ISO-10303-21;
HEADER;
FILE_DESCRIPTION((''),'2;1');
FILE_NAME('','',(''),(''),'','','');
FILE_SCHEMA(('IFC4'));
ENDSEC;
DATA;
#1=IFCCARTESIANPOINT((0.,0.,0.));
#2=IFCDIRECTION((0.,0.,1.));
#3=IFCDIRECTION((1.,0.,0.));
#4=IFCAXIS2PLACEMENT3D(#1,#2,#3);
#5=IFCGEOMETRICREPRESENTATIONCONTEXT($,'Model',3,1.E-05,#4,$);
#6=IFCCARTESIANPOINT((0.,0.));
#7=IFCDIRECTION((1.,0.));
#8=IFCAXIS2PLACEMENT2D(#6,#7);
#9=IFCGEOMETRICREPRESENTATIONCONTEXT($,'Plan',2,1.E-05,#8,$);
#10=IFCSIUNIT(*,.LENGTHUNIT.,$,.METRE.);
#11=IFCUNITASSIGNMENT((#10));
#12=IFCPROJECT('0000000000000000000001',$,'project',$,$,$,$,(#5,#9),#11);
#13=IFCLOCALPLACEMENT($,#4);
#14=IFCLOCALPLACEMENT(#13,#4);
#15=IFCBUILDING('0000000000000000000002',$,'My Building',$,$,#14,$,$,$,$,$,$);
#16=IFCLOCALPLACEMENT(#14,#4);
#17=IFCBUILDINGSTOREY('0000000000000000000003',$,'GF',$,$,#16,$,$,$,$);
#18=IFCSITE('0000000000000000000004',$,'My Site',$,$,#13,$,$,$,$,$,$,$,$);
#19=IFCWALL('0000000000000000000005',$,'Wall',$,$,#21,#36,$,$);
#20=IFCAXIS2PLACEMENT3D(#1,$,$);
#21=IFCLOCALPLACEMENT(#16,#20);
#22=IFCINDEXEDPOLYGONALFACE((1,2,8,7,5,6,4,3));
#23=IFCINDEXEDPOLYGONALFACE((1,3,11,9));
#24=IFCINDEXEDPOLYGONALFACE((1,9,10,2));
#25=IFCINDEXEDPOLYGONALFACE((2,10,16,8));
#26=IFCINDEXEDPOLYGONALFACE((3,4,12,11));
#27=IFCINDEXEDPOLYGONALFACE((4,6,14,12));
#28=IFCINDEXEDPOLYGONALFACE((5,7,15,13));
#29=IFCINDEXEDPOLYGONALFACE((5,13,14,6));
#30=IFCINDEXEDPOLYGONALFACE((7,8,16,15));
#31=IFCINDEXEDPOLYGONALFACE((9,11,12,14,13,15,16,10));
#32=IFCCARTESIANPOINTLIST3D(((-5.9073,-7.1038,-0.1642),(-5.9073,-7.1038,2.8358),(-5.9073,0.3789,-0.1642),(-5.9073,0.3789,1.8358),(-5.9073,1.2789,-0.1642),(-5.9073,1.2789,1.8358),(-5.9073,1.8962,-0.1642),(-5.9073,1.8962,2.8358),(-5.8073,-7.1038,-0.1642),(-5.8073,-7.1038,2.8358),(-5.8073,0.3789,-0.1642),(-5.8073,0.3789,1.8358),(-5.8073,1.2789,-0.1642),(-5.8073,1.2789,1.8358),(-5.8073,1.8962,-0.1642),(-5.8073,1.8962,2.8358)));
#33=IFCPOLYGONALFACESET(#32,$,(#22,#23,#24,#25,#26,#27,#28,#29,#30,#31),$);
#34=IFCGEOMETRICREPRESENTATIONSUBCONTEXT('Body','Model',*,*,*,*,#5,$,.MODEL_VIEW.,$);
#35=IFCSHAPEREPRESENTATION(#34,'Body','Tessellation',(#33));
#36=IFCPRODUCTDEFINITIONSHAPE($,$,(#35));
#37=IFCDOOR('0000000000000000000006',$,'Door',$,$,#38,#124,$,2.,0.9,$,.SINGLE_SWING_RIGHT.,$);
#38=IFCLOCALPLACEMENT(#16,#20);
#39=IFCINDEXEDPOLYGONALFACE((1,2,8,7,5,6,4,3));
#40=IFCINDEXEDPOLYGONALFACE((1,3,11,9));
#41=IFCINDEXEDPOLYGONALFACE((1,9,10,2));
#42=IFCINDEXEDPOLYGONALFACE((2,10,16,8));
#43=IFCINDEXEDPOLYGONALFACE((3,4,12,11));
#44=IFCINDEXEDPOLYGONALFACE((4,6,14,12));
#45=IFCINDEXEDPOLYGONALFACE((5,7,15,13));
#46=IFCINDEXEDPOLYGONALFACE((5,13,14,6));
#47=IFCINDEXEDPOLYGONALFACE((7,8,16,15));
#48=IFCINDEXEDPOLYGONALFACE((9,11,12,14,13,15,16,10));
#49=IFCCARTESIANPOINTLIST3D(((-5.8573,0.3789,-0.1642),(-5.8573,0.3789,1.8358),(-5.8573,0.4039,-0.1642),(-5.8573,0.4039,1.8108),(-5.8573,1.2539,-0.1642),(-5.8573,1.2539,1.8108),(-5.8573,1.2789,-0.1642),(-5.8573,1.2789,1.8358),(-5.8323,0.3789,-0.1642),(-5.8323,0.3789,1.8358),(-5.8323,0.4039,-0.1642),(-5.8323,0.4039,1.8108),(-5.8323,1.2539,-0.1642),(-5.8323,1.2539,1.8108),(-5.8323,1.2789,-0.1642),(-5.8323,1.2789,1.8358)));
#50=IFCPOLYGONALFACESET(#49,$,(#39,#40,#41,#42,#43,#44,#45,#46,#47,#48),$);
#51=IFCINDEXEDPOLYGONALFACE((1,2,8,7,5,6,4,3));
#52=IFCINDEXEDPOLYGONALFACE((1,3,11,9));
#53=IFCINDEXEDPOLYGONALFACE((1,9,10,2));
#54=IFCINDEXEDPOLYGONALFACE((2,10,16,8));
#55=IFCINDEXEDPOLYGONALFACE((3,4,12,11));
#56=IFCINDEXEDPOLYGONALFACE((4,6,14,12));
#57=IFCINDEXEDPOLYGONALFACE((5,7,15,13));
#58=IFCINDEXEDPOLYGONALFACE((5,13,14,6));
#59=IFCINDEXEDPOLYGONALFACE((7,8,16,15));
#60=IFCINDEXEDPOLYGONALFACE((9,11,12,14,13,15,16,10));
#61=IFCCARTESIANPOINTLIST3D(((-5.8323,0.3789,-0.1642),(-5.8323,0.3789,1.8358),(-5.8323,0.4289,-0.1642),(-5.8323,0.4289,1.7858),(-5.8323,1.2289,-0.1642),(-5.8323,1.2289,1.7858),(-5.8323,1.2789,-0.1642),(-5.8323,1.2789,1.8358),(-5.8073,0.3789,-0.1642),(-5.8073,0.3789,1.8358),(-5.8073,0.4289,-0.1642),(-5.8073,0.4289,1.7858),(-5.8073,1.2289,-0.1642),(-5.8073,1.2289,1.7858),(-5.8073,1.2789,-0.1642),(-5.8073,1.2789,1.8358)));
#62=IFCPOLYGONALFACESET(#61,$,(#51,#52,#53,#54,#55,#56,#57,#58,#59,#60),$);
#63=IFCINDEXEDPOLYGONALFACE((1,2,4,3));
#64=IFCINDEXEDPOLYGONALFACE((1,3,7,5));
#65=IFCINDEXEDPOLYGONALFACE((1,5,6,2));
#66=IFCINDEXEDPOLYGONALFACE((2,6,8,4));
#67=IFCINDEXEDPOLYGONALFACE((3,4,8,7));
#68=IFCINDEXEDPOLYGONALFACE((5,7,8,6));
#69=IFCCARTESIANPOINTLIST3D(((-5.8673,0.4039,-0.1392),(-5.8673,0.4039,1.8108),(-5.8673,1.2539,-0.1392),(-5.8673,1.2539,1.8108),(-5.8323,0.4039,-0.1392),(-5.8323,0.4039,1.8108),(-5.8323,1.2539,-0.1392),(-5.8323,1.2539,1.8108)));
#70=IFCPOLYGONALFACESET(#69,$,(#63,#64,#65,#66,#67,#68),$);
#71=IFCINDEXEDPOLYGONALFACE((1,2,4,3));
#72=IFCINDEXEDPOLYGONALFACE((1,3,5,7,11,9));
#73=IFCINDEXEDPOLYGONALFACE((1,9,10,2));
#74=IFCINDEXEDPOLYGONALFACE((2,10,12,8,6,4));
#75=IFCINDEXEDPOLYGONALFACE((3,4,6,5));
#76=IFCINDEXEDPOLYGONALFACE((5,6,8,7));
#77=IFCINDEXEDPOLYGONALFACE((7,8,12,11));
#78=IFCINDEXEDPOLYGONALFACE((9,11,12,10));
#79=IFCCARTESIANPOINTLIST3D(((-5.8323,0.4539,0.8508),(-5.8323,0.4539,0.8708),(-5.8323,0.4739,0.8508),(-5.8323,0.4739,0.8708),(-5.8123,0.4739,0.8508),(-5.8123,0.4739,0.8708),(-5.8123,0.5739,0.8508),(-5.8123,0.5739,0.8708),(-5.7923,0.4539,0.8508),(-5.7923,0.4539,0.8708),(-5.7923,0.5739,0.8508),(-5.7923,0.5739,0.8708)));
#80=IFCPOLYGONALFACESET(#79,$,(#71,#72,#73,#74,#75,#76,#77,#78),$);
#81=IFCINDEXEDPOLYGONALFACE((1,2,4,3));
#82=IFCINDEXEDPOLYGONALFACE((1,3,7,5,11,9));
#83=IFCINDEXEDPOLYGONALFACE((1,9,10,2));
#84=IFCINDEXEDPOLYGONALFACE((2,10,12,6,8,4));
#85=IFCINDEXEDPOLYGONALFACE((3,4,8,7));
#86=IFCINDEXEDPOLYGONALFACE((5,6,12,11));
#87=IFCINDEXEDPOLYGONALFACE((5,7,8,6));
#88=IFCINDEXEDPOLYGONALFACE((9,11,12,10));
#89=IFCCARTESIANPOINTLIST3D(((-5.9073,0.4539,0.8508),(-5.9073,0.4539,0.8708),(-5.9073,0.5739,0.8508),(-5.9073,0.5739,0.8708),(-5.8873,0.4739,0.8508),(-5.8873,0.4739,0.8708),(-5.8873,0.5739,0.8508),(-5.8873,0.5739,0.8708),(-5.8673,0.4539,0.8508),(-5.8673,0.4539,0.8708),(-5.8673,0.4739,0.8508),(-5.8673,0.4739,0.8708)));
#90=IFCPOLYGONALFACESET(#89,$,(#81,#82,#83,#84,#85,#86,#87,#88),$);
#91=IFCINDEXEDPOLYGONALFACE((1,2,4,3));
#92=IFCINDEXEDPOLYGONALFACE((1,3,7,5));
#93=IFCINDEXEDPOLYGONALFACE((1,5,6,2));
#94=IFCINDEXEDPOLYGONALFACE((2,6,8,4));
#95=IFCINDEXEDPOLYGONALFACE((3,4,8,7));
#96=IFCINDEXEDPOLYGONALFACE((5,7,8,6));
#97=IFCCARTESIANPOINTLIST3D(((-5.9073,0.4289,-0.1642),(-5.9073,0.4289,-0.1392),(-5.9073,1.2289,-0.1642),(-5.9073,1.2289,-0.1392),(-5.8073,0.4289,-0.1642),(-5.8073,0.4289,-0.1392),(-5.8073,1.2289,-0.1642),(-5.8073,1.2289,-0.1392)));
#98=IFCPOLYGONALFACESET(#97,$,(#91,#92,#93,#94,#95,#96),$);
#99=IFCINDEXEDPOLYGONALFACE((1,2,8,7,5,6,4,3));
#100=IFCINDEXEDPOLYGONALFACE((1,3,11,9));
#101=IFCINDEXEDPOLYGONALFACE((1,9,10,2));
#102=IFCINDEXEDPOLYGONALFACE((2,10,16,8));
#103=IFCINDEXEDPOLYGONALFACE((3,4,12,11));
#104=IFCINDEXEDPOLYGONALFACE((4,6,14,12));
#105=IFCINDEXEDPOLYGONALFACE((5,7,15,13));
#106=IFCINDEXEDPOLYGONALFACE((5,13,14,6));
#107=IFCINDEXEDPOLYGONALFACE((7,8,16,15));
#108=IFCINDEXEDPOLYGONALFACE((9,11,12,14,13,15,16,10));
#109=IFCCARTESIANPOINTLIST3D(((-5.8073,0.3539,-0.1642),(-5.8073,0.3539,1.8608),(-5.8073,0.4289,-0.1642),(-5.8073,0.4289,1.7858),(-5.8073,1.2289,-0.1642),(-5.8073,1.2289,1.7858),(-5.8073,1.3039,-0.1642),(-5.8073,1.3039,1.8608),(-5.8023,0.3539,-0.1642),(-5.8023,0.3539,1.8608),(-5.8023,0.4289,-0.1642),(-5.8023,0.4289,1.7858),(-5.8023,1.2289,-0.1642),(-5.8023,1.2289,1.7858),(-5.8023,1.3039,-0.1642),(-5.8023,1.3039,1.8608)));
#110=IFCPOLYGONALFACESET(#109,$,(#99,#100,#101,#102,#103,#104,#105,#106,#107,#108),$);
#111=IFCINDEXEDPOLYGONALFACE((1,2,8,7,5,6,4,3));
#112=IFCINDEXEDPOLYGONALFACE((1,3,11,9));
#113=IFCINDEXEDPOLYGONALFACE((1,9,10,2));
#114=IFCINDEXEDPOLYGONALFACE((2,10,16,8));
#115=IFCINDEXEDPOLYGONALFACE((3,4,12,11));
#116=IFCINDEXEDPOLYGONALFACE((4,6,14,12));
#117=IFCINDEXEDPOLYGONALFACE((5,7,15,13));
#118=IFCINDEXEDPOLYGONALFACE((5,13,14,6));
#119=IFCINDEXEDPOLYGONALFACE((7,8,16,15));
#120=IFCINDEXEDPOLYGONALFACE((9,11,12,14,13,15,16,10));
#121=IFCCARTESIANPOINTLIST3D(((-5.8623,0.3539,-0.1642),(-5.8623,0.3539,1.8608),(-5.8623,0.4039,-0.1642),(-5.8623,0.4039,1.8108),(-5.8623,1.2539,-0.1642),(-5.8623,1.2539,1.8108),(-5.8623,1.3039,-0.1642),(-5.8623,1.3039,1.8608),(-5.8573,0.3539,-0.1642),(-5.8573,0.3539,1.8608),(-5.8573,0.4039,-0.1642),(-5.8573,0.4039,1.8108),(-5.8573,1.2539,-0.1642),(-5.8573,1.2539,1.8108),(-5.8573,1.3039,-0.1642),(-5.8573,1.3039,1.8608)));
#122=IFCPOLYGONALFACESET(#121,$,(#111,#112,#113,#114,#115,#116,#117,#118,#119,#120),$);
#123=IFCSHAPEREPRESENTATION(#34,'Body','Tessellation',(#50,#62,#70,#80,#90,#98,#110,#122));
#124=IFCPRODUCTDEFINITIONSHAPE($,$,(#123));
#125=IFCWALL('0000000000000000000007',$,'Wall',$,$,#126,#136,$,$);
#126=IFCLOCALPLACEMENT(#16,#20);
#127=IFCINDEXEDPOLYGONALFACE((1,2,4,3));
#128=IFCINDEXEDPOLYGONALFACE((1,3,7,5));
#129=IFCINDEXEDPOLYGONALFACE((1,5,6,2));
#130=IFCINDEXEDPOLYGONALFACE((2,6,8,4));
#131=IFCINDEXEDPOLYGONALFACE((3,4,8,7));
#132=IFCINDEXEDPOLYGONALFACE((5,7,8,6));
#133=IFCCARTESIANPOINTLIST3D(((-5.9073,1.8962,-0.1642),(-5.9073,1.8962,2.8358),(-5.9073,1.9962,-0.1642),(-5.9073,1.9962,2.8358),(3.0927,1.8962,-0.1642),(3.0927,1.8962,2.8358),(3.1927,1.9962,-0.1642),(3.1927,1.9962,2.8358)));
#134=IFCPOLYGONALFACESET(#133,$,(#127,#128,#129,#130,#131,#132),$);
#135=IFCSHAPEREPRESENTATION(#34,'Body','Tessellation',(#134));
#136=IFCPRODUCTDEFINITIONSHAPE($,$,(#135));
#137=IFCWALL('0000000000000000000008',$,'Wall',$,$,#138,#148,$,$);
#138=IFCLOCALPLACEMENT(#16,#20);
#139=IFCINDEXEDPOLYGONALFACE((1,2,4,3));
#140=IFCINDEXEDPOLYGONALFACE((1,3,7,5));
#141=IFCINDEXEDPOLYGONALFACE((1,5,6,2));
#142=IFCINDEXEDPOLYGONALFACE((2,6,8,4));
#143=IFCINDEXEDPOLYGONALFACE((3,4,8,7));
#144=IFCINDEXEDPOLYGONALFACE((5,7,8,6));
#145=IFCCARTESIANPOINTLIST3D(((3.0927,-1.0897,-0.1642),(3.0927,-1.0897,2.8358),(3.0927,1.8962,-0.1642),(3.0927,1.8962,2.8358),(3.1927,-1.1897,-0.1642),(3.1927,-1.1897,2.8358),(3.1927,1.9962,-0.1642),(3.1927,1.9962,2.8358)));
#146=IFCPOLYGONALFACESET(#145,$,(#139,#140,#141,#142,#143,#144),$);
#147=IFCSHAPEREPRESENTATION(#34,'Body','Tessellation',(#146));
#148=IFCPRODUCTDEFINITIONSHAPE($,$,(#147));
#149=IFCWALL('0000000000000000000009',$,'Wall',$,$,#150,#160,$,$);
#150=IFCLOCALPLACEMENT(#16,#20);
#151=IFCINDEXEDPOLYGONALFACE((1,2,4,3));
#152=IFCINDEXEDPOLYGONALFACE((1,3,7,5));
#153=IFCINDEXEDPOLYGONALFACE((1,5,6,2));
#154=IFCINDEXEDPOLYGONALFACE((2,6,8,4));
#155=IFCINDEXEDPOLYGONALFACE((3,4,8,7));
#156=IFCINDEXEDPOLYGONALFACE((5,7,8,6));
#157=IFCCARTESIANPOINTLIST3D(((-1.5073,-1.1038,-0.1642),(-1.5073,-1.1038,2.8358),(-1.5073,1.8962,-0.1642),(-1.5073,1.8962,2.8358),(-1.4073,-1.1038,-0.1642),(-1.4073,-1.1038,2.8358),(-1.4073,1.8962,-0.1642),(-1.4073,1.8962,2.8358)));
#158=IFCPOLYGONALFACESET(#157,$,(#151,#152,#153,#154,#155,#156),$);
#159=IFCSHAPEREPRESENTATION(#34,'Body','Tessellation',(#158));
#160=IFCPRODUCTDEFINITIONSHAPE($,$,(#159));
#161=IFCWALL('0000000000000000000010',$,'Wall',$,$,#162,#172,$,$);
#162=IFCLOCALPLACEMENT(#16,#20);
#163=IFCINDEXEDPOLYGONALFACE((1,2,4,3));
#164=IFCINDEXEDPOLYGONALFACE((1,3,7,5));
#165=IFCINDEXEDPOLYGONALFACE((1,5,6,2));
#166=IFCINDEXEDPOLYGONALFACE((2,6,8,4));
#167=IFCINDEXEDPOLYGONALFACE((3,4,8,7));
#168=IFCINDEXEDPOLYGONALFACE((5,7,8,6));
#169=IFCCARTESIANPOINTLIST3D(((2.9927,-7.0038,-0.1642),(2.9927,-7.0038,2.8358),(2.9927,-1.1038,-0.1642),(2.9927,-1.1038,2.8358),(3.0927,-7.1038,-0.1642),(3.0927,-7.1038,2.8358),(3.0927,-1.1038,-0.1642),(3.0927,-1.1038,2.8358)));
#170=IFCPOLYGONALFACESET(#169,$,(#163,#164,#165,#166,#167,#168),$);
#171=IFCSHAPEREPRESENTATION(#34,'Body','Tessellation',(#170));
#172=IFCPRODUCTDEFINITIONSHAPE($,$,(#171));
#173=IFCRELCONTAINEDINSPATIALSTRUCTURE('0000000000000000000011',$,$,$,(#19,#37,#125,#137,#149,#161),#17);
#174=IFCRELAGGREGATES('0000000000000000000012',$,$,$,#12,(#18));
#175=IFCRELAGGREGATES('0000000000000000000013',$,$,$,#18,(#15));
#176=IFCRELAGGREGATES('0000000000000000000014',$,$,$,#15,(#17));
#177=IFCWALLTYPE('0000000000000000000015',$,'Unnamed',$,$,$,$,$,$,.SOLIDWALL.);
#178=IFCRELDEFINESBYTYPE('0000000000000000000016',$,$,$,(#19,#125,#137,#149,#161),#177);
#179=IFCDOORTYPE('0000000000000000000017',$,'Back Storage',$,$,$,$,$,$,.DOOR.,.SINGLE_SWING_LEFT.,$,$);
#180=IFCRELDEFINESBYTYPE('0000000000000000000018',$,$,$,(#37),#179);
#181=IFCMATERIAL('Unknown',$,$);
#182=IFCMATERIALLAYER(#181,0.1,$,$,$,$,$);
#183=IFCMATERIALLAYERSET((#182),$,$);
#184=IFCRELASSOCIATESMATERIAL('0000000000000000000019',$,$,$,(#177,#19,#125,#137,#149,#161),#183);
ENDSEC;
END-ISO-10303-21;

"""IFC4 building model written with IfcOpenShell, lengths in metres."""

from ifc_helpers import new_model, entity, si_unit, frame, origin_with_axes, origin_2d_with_axis, place, context, subcontext, project, spatial, line, indexed_curve, outline, extrude, shape, source, transform, mapped, material, layer, layer_set, layer_usage, type_object, type_shapes, element, fill, save


model = new_model("IFC4")

# Units and contexts
model_context = context("Model", 3, precision=1e-05, world=origin_with_axes())
plan_context = context("Plan", 2, precision=1e-05, world=origin_2d_with_axis())
body_context_1 = subcontext(model_context, "Body", "Model", "MODEL_VIEW")
body_context_2 = subcontext(plan_context, "Body", "Plan", "PLAN_VIEW")
ifc_project = project(units=[si_unit("LENGTHUNIT", "METRE")], contexts=[model_context, plan_context])

# Site, building, storey
site_placement = place(None, origin_with_axes())
site = spatial("IfcSite", under=ifc_project, at=site_placement, Name="My Site")
building_placement = place(site_placement, origin_with_axes())
building = spatial("IfcBuilding", under=site, at=building_placement, Name="My Building")
storey_placement = place(building_placement, origin_with_axes())
storey = spatial("IfcBuildingStorey", under=building, at=storey_placement, Name="GF")

# Shared definitions
ifc_material = material(Name="Unknown")

# Wall, opening, door
ifc_layer_1 = layer(ifc_material, 0.1)
ifc_layer_set_1 = layer_set([ifc_layer_1])
ifc_layer_usage_1 = layer_usage(ifc_layer_set_1, "AXIS2", "POSITIVE", 0.0)
wall_type = type_object("IfcWallType", Name="Unnamed", PredefinedType="SOLIDWALL", material=ifc_layer_set_1)
wall_1_placement = place(storey_placement, frame((-5.9073, 1.8962, -0.1642), z_axis=(0.0, 0.0, 1.0), x_axis=(0.0, -1.0, 0.0)))
wall_1 = element("IfcWall", 1, at=wall_1_placement, inside=storey, type_object=wall_type, material=ifc_layer_usage_1, Name="Wall", context=body_context_1, shape_type="SweptSolid", body=[
    extrude(outline(indexed_curve([(0.0, 0.0), (0.0, 0.1), (9.0, 0.1), (9.0, 0.0)], segments=[line(1, 2, 3, 4, 1)])), origin_with_axes(), (0.0, 0.0, 1.0), 3.0),
])
shared_shape_1 = source(origin_with_axes(), body_context_1, "Body", "SweptSolid", [
    extrude(outline(indexed_curve([(0.0, 0.0), (0.9, 0.0), (0.9, 2.0), (0.0, 2.0)], segments=[line(1, 2, 3, 4, 1)])), frame((0.0, -0.6, 0.0), z_axis=(0.0, -1.0, 0.0), x_axis=(1.0, 0.0, 0.0)), (0.0, 0.0, -1.0), 1.2),
])
opening_1_placement = place(wall_1_placement, frame((1.5173, 0.1, 0.0), z_axis=(0.0, 0.0, 1.0), x_axis=(-1.0, 0.0, 0.0)))
opening_1 = element("IfcOpeningElement", 2, at=opening_1_placement, cuts=wall_1, PredefinedType="OPENING", context=body_context_1, shape_type="MappedRepresentation", body=[
    mapped(shared_shape_1, transform((0.0, 0.0, 0.0), x_axis=(1.0, 0.0, 0.0), y_axis=(0.0, 1.0, 0.0), z_axis=(0.0, 0.0, 1.0), scale=1.0)),
])
door_type_1 = type_object("IfcDoorType", Name="Back Storage", OperationType="SINGLE_SWING_LEFT", PredefinedType="DOOR")
shared_shape_2 = source(origin_with_axes(), body_context_1, "Body", "SweptSolid", [
    extrude(outline(indexed_curve([(0.0, 0.0), (0.0, 2.0), (0.9, 2.0), (0.9, 0.0), (0.875, 0.0), (0.875, 1.975), (0.025, 1.975), (0.025, 0.0)], segments=[line(1, 2, 3, 4, 5, 6, 7, 8, 1)])), frame((0.0, 0.025, 0.0), z_axis=(0.0, -1.0, 0.0), x_axis=(1.0, 0.0, 0.0)), (0.0, 0.0, -1.0), 0.025),
    extrude(outline(indexed_curve([(0.0, 0.0), (0.0, 2.0), (0.9, 2.0), (0.9, 0.0), (0.85, 0.0), (0.85, 1.95), (0.05, 1.95), (0.05, 0.0)], segments=[line(1, 2, 3, 4, 5, 6, 7, 8, 1)])), frame((0.0, 0.0, 0.0), z_axis=(0.0, -1.0, 0.0), x_axis=(1.0, 0.0, 0.0)), (0.0, 0.0, -1.0), 0.025),
    extrude(outline(indexed_curve([(0.0, 0.0), (0.85, 0.0), (0.85, 0.035), (0.0, 0.035)], segments=[line(1, 2, 3, 4, 1)])), frame((0.025, 0.025, 0.025), z_axis=(0.0, 0.0, 1.0), x_axis=(1.0, 0.0, 0.0)), (0.0, 0.0, 1.0), 1.95),
    extrude(outline(indexed_curve([(0.0, 0.0), (0.0, -0.04), (0.12, -0.04), (0.12, -0.02), (0.02, -0.02), (0.02, 0.0)], segments=[line(1, 2, 3, 4, 5, 6, 1)])), frame((0.075, 0.025, 1.015), z_axis=(0.0, 0.0, 1.0), x_axis=(1.0, 0.0, 0.0)), (0.0, 0.0, 1.0), 0.02),
    extrude(outline(indexed_curve([(0.0, 0.0), (0.0, 0.04), (0.12, 0.04), (0.12, 0.02), (0.02, 0.02), (0.02, 0.0)], segments=[line(1, 2, 3, 4, 5, 6, 1)])), frame((0.075, 0.06, 1.015), z_axis=(0.0, 0.0, 1.0), x_axis=(1.0, 0.0, 0.0)), (0.0, 0.0, 1.0), 0.02),
    extrude(outline(indexed_curve([(0.0, 0.0), (0.8, 0.0), (0.8, 0.1), (0.0, 0.1)], segments=[line(1, 2, 3, 4, 1)])), frame((0.05, 0.0, 0.0), z_axis=(0.0, 0.0, 1.0), x_axis=(1.0, 0.0, 0.0)), (0.0, 0.0, 1.0), 0.025),
    extrude(outline(indexed_curve([(0.0, 0.0), (0.0, 2.025), (0.95, 2.025), (0.95, 0.0), (0.875, 0.0), (0.875, 1.95), (0.075, 1.95), (0.075, 0.0)], segments=[line(1, 2, 3, 4, 5, 6, 7, 8, 1)])), frame((-0.025, -0.005, 0.0), z_axis=(0.0, -1.0, 0.0), x_axis=(1.0, 0.0, 0.0)), (0.0, 0.0, -1.0), 0.005),
    extrude(outline(indexed_curve([(0.0, 0.0), (0.0, 2.025), (0.95, 2.025), (0.95, 0.0), (0.9, 0.0), (0.9, 1.975), (0.05, 1.975), (0.05, 0.0)], segments=[line(1, 2, 3, 4, 5, 6, 7, 8, 1)])), frame((-0.025, 0.05, 0.0), z_axis=(0.0, -1.0, 0.0), x_axis=(1.0, 0.0, 0.0)), (0.0, 0.0, -1.0), 0.005),
])
shared_shape_3 = source(origin_with_axes(), body_context_2, "Body", "Curve2D", [
    entity("IfcIndexedPolyCurve", entity("IfcCartesianPointList2D", [[0.0, 0.0], [0.0, 0.05], [0.025, 0.05], [0.025, 0.025], [0.05, 0.025], [0.05, 0.0]]), [entity("IfcLineIndex", [1, 2, 3, 4, 5, 6, 1])]),
    entity("IfcIndexedPolyCurve", entity("IfcCartesianPointList2D", [[0.9, 0.0], [0.9, 0.05], [0.875, 0.05], [0.875, 0.025], [0.85, 0.025], [0.85, 0.0]]), [entity("IfcLineIndex", [1, 2, 3, 4, 5, 6, 1])]),
    entity("IfcTrimmedCurve", entity("IfcEllipse", entity("IfcAxis2Placement2D", entity("IfcCartesianPoint", [0.84, 0.05]), entity("IfcDirection", [1.0, 0.0])), 0.815, 0.85), [entity("IfcCartesianPoint", [0.84, 0.9])], [entity("IfcCartesianPoint", [0.025, 0.05])], True, "CARTESIAN"),
    entity("IfcIndexedPolyCurve", entity("IfcCartesianPointList2D", [[0.875, 0.05], [0.84, 0.05], [0.84, 0.9], [0.875, 0.9]]), [entity("IfcLineIndex", [1, 2, 3, 4, 1])]),
])
type_shapes(door_type_1, [shared_shape_2, shared_shape_3])
door_1_placement = place(opening_1_placement, frame((0.0, 0.0, 0.0), z_axis=(0.0, 0.0, 1.0), x_axis=(1.0, 0.0, 0.0)))
door_1 = element("IfcDoor", 3, at=door_1_placement, inside=storey, type_object=door_type_1, Name="Door", OperationType="SINGLE_SWING_RIGHT", OverallHeight=2.0, OverallWidth=0.9, shapes=[
    shape(body_context_1, "Body", "MappedRepresentation", [mapped(shared_shape_2, transform((0.0, 0.0, 0.0), x_axis=(1.0, 0.0, 0.0), y_axis=(0.0, 1.0, 0.0), z_axis=(0.0, 0.0, 1.0), scale=1.0))]),
    shape(body_context_2, "Body", "MappedRepresentation", [mapped(shared_shape_3, transform((0.0, 0.0, 0.0), x_axis=(1.0, 0.0, 0.0), y_axis=(0.0, 1.0, 0.0), z_axis=(0.0, 0.0, 1.0), scale=1.0))]),
])
fill(opening_1, door_1)

# Walls
ifc_layer_usage_2 = layer_usage(ifc_layer_set_1, "AXIS2", "POSITIVE", 0.0)
wall_2_placement = place(storey_placement, frame((-5.9073, 1.8962, -0.1642), z_axis=(0.0, 0.0, 1.0), x_axis=(1.0, 0.0, 0.0)))
element("IfcWall", 4, at=wall_2_placement, inside=storey, type_object=wall_type, material=ifc_layer_usage_2, Name="Wall", context=body_context_1, shape_type="SweptSolid", body=[
    extrude(outline(indexed_curve([(0.0, 0.0), (0.0, 0.1), (9.1, 0.1), (9.0, 0.0)], segments=[line(1, 2, 3, 4, 1)])), origin_with_axes(), (0.0, 0.0, 1.0), 3.0),
])
ifc_layer_usage_3 = layer_usage(ifc_layer_set_1, "AXIS2", "POSITIVE", 0.0)
wall_3_placement = place(storey_placement, frame((3.0927, 1.8962, -0.1642), z_axis=(0.0, 0.0, 1.0), x_axis=(0.0, -1.0, 0.0)))
element("IfcWall", 5, at=wall_3_placement, inside=storey, type_object=wall_type, material=ifc_layer_usage_3, Name="Wall", context=body_context_1, shape_type="SweptSolid", body=[
    extrude(outline(indexed_curve([(0.0, 0.0), (-0.1, 0.1), (3.0858, 0.1), (2.9858, 0.0)], segments=[line(1, 2, 3, 4, 1)])), origin_with_axes(), (0.0, 0.0, 1.0), 3.0),
])

# Wall
ifc_layer_usage_4 = layer_usage(ifc_layer_set_1, "AXIS2", "POSITIVE", 0.0)
wall_4_placement = place(storey_placement, frame((-1.4073, -1.1038, -0.1642), z_axis=(0.0, 0.0, 1.0), x_axis=(0.0, 1.0, 0.0)))
element("IfcWall", 6, at=wall_4_placement, inside=storey, type_object=wall_type, material=ifc_layer_usage_4, Name="Wall", context=body_context_1, shape_type="SweptSolid", body=[
    extrude(outline(indexed_curve([(0.0, 0.0), (0.0, 0.1), (3.0, 0.1), (3.0, 0.0)], segments=[line(1, 2, 3, 4, 1)])), origin_with_axes(), (0.0, 0.0, 1.0), 3.0),
])

# Wall
ifc_layer_usage_5 = layer_usage(ifc_layer_set_1, "AXIS2", "POSITIVE", 0.0)
wall_5_placement = place(storey_placement, frame((3.0927, -7.1038, -0.1642), z_axis=(0.0, 0.0, 1.0), x_axis=(0.0, 1.0, 0.0)))
element("IfcWall", 7, at=wall_5_placement, inside=storey, type_object=wall_type, material=ifc_layer_usage_5, Name="Wall", context=body_context_1, shape_type="SweptSolid", body=[
    extrude(outline(indexed_curve([(0.0, 0.0), (0.1, 0.1), (6.0, 0.1), (6.0, 0.0)], segments=[line(1, 2, 3, 4, 1)])), origin_with_axes(), (0.0, 0.0, 1.0), 3.0),
])

save(model, "model.ifc")
